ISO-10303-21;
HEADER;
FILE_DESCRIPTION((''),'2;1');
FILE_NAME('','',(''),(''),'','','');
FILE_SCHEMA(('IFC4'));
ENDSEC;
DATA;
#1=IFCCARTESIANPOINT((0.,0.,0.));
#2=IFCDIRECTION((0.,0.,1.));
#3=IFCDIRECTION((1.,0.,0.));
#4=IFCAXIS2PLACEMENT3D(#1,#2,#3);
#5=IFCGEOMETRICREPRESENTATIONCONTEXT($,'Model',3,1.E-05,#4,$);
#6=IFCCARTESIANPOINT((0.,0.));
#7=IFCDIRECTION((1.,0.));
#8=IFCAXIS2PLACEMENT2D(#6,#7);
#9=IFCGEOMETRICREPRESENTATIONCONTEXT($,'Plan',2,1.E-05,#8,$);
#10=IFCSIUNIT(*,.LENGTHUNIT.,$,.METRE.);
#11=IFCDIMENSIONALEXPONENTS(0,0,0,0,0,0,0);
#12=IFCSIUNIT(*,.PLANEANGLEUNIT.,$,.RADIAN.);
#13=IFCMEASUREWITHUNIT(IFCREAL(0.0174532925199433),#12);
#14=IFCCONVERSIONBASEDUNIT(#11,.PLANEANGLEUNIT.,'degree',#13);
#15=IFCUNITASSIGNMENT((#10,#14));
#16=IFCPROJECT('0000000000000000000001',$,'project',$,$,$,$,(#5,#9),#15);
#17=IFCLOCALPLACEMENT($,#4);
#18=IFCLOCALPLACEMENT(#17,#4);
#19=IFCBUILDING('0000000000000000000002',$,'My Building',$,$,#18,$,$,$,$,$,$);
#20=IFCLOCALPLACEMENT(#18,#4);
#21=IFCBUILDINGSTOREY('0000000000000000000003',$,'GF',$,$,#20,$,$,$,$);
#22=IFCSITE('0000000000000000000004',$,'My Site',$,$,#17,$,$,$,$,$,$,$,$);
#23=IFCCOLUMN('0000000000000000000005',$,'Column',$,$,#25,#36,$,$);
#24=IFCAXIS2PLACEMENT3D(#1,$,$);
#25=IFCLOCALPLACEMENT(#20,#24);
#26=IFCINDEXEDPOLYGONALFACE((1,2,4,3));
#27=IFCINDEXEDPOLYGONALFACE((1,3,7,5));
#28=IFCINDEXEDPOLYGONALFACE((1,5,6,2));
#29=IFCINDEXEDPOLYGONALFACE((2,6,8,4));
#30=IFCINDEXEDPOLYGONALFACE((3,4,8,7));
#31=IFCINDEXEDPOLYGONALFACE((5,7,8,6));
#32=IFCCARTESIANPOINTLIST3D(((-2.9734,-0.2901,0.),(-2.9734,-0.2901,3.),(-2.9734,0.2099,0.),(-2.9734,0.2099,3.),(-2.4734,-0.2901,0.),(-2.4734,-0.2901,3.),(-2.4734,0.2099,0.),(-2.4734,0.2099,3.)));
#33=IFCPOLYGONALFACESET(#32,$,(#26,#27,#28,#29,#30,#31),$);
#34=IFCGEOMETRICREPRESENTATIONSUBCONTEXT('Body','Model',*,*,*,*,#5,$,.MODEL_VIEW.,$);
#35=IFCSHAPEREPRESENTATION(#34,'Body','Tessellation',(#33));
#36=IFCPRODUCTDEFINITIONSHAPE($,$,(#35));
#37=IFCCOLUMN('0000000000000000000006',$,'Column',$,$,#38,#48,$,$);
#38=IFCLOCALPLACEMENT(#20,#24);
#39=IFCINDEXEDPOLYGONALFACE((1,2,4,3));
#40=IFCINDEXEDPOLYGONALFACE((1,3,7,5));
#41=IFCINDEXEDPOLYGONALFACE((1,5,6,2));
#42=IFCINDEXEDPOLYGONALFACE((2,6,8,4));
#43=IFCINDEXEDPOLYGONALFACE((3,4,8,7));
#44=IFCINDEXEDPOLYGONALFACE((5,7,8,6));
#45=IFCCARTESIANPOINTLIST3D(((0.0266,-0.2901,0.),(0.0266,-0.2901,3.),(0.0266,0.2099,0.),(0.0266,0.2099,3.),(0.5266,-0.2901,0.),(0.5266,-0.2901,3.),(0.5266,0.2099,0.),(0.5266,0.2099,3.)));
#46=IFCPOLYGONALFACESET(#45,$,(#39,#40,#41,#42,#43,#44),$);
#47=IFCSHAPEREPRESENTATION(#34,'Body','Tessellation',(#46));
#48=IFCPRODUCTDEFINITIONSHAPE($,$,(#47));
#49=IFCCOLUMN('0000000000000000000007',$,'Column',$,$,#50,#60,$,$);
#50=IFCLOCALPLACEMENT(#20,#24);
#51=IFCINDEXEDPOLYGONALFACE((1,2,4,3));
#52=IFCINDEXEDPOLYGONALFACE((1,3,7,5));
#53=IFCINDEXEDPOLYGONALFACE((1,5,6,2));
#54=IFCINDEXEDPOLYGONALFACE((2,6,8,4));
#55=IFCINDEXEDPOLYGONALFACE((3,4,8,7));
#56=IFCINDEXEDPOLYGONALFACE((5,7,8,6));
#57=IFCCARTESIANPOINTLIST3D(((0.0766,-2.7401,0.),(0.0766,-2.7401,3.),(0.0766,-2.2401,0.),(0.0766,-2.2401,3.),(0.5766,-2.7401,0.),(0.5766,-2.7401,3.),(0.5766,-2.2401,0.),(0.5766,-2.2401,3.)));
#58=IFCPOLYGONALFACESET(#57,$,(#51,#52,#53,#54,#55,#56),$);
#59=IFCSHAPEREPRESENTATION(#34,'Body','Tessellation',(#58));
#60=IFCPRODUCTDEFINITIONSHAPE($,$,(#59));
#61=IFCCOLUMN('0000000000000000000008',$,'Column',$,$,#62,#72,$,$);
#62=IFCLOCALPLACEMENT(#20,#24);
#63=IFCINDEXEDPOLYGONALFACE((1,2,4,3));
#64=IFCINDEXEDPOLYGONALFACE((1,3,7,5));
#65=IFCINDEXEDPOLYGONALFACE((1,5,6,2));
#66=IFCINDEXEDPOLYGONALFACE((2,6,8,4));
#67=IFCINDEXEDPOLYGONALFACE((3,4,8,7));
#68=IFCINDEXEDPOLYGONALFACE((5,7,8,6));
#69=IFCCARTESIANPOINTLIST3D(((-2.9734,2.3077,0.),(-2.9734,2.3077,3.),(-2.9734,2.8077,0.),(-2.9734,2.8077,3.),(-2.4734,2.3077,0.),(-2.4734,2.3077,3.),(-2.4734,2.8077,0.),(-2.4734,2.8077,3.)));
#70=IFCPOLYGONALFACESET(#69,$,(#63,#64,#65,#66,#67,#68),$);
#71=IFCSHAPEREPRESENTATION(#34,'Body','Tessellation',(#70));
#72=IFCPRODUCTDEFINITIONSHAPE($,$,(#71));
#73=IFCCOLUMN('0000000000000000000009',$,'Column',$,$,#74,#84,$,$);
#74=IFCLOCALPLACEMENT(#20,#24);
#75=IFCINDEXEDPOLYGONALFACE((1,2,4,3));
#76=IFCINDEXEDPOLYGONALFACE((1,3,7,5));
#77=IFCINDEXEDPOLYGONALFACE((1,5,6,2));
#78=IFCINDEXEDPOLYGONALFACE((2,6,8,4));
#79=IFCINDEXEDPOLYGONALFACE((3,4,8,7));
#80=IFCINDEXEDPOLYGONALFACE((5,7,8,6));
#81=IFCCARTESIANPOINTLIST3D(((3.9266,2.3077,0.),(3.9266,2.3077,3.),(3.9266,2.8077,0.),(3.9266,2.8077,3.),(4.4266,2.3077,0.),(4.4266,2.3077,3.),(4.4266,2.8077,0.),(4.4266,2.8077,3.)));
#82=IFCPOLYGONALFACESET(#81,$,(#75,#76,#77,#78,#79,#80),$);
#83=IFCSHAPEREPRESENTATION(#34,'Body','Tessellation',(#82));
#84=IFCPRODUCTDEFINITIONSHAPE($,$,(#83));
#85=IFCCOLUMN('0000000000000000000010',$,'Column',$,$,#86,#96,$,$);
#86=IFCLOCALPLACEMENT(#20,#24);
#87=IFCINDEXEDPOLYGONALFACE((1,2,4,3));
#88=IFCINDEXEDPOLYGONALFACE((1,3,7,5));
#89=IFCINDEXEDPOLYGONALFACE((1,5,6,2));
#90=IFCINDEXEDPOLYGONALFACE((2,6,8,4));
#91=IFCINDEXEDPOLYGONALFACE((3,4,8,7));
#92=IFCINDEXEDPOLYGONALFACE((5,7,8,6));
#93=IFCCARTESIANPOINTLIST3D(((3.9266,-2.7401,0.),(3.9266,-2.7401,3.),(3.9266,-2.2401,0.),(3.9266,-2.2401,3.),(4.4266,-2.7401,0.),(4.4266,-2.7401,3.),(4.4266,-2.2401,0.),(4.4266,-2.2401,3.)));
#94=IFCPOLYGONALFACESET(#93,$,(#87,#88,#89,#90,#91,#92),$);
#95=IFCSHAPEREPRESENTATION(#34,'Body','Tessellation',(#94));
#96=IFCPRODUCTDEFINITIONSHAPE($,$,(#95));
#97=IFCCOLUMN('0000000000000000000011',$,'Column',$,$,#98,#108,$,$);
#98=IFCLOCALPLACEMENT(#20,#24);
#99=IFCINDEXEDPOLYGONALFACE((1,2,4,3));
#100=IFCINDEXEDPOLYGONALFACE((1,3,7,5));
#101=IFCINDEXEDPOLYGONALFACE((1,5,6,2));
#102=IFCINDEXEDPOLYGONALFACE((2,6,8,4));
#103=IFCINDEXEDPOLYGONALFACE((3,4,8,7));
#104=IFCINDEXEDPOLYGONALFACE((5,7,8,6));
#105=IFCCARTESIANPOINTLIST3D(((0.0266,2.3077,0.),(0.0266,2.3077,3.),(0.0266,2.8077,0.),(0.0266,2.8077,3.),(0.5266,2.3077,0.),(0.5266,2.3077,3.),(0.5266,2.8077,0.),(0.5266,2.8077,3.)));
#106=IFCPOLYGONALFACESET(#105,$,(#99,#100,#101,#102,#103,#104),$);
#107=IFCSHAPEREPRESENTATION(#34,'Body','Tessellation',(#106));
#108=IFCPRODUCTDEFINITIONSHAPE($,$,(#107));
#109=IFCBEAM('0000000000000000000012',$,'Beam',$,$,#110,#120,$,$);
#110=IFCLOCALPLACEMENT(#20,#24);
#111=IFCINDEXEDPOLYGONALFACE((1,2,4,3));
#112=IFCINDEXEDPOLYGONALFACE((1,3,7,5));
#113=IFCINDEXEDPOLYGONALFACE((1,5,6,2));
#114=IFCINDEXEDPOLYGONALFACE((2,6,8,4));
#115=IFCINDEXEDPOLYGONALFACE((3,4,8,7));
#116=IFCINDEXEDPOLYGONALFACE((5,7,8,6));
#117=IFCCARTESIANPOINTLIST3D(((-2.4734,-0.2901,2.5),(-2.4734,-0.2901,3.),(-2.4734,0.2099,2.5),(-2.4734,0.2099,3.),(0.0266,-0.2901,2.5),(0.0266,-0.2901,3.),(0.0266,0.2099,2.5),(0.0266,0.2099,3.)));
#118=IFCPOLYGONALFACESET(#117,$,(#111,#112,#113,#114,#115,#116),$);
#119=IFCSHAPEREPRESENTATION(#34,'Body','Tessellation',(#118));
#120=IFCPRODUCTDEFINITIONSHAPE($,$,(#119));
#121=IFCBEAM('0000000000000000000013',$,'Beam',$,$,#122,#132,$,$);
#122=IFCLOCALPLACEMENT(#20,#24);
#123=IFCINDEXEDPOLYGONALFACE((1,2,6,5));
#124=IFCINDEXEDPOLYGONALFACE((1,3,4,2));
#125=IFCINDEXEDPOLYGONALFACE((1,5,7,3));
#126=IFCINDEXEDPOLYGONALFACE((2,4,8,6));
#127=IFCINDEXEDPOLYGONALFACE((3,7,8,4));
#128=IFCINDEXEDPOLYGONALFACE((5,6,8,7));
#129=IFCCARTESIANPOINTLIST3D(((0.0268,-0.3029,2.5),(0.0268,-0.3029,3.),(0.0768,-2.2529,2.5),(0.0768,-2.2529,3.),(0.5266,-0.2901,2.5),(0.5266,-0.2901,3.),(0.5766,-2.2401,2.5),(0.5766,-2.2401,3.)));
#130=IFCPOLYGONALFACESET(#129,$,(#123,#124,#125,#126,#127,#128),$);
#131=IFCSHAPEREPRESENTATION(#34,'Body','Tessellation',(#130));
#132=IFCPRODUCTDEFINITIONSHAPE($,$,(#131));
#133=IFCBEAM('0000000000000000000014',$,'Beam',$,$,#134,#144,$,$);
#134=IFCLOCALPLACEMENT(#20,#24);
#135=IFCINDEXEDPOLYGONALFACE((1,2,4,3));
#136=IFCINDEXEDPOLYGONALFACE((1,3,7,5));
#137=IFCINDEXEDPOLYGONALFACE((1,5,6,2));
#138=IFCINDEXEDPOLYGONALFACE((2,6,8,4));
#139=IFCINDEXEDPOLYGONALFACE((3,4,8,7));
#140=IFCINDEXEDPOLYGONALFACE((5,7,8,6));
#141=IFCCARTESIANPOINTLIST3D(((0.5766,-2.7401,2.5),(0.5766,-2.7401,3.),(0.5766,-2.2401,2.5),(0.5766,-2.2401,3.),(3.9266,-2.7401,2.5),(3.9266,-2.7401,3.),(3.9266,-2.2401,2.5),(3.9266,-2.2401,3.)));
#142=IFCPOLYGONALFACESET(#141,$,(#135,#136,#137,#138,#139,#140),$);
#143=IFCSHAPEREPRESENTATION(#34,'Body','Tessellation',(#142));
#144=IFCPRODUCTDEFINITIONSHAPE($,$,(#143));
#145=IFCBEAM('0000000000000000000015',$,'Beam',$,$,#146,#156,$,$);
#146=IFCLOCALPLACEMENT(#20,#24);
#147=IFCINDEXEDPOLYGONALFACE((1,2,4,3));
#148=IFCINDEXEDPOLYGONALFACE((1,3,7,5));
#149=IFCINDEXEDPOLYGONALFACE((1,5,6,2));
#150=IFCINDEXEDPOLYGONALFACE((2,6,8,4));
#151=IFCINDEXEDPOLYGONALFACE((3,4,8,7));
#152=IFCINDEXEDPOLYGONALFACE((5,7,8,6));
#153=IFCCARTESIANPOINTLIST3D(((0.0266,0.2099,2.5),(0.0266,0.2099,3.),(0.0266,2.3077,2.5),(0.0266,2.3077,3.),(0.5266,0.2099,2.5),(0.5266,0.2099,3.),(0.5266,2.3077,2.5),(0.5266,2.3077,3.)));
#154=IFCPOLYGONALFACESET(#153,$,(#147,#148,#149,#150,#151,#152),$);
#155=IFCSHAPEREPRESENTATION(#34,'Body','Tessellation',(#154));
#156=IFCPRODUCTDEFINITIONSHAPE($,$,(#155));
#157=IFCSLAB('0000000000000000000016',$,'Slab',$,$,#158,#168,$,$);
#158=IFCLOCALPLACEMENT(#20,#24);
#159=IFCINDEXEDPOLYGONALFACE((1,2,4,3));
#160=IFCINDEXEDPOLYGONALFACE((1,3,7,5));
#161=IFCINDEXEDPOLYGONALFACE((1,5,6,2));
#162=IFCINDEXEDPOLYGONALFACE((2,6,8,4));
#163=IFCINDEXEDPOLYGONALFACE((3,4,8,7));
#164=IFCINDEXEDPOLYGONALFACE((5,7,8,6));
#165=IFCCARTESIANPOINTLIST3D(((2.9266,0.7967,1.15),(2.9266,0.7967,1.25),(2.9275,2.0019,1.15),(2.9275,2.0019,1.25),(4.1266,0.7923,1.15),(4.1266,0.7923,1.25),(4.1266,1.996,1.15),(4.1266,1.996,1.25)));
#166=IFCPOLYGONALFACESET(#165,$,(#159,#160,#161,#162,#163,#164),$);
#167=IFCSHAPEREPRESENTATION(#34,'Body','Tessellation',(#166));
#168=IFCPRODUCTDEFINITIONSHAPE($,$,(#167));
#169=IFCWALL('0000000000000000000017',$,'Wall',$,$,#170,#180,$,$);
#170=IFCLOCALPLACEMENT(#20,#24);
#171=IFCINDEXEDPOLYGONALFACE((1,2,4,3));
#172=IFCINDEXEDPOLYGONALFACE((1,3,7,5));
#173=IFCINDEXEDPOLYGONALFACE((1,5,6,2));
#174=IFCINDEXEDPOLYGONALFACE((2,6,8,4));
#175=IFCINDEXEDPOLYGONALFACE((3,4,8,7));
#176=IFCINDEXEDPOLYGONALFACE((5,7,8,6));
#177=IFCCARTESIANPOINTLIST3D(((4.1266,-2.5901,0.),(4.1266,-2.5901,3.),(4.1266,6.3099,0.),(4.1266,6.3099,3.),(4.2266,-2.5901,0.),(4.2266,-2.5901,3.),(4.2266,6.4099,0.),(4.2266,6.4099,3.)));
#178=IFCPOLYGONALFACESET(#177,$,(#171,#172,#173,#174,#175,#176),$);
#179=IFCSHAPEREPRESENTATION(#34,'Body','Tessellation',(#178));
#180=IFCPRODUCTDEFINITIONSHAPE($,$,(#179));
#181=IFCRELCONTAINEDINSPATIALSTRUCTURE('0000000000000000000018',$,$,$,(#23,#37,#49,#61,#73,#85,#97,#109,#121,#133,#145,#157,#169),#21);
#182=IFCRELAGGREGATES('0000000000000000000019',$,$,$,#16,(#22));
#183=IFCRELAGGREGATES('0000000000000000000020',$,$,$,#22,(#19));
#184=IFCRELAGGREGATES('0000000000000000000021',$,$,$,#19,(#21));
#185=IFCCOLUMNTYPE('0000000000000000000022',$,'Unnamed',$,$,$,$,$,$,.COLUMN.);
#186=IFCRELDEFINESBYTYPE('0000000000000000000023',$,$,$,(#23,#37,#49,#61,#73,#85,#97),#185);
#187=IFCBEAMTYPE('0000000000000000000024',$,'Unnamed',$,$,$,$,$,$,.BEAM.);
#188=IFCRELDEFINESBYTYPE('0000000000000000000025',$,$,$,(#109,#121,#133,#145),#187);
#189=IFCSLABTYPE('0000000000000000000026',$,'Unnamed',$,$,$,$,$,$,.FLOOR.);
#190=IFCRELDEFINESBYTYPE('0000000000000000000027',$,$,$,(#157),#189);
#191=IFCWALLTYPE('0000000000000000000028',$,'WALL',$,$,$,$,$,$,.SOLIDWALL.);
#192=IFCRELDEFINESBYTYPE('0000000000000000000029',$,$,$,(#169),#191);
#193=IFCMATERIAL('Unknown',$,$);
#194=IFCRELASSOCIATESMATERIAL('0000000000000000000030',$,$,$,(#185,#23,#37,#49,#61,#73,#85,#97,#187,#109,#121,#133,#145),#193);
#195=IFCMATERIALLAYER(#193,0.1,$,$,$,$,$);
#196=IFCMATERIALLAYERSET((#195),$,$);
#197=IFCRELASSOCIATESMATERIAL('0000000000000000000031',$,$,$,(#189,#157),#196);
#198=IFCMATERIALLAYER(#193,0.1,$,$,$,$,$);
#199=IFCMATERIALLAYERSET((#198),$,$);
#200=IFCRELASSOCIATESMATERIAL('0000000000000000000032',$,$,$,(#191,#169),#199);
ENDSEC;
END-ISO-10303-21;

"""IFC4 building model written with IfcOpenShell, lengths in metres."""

from ifc_helpers import new_model, entity, si_unit, converted_unit, frame, origin_with_axes, origin_2d_with_axis, place, context, subcontext, project, spatial, line, indexed_curve, rectangle, outline, extrude, material, layer, layer_set, layer_usage, material_profile, profile_set, profile_usage, type_object, element, save


model = new_model("IFC4")

# Units and contexts
model_context = context("Model", 3, precision=1e-05, world=origin_with_axes())
plan_context = context("Plan", 2, precision=1e-05, world=origin_2d_with_axis())
body_context_1 = subcontext(model_context, "Body", "Model", "MODEL_VIEW")
ifc_project = project(units=[si_unit("LENGTHUNIT", "METRE"), converted_unit("PLANEANGLEUNIT", "degree", entity("IfcReal", 0.0174532925199433), si_unit("PLANEANGLEUNIT", "RADIAN"), dimensions=[0, 0, 0, 0, 0, 0, 0])], contexts=[model_context, plan_context])

# Site, building, storey
site_placement = place(None, origin_with_axes())
site = spatial("IfcSite", under=ifc_project, at=site_placement, Name="My Site")
building_placement = place(site_placement, origin_with_axes())
building = spatial("IfcBuilding", under=site, at=building_placement, Name="My Building")
storey_placement = place(building_placement, origin_with_axes())
storey = spatial("IfcBuildingStorey", under=building, at=storey_placement, Name="GF")

# Columns
ifc_material_1 = material(Name="Unknown")
ifc_material_profile_1 = material_profile(ifc_material_1, rectangle(XDim=0.5, YDim=0.5))
ifc_profile_set_1 = profile_set([ifc_material_profile_1])
ifc_profile_usage_1 = profile_usage(ifc_profile_set_1, cardinal=5)
column_type = type_object("IfcColumnType", Name="Unnamed", PredefinedType="COLUMN", material=ifc_profile_set_1)
column_1_placement = place(storey_placement, frame((-2.7234, -0.0401, 0.0), z_axis=(0.0, 0.0, 1.0), x_axis=(1.0, 0.0, 0.0)))
element("IfcColumn", 1, at=column_1_placement, inside=storey, type_object=column_type, material=ifc_profile_usage_1, Name="Column", context=body_context_1, shape_type="SweptSolid", body=[
    extrude(rectangle(XDim=0.5, YDim=0.5), origin_with_axes(), (0.0, 0.0, 1.0), 3.0),
])
ifc_profile_usage_2 = profile_usage(ifc_profile_set_1, cardinal=5)
column_2_placement = place(storey_placement, frame((0.2766, -0.0401, 0.0), z_axis=(0.0, 0.0, 1.0), x_axis=(1.0, 0.0, 0.0)))
element("IfcColumn", 2, at=column_2_placement, inside=storey, type_object=column_type, material=ifc_profile_usage_2, Name="Column", context=body_context_1, shape_type="SweptSolid", body=[
    extrude(rectangle(XDim=0.5, YDim=0.5), origin_with_axes(), (0.0, 0.0, 1.0), 3.0),
])
ifc_profile_usage_3 = profile_usage(ifc_profile_set_1, cardinal=5)
column_3_placement = place(storey_placement, frame((0.3266, -2.4901, 0.0), z_axis=(0.0, 0.0, 1.0), x_axis=(1.0, 0.0, 0.0)))
element("IfcColumn", 3, at=column_3_placement, inside=storey, type_object=column_type, material=ifc_profile_usage_3, Name="Column", context=body_context_1, shape_type="SweptSolid", body=[
    extrude(rectangle(XDim=0.5, YDim=0.5), origin_with_axes(), (0.0, 0.0, 1.0), 3.0),
])
ifc_profile_usage_4 = profile_usage(ifc_profile_set_1, cardinal=5)
column_4_placement = place(storey_placement, frame((-2.7234, 2.5577, 0.0), z_axis=(0.0, 0.0, 1.0), x_axis=(1.0, 0.0, 0.0)))
element("IfcColumn", 4, at=column_4_placement, inside=storey, type_object=column_type, material=ifc_profile_usage_4, Name="Column", context=body_context_1, shape_type="SweptSolid", body=[
    extrude(rectangle(XDim=0.5, YDim=0.5), origin_with_axes(), (0.0, 0.0, 1.0), 3.0),
])
ifc_profile_usage_5 = profile_usage(ifc_profile_set_1, cardinal=5)
column_5_placement = place(storey_placement, frame((4.1766, 2.5577, 0.0), z_axis=(0.0, 0.0, 1.0), x_axis=(1.0, 0.0, 0.0)))
element("IfcColumn", 5, at=column_5_placement, inside=storey, type_object=column_type, material=ifc_profile_usage_5, Name="Column", context=body_context_1, shape_type="SweptSolid", body=[
    extrude(rectangle(XDim=0.5, YDim=0.5), origin_with_axes(), (0.0, 0.0, 1.0), 3.0),
])
ifc_profile_usage_6 = profile_usage(ifc_profile_set_1, cardinal=5)
column_6_placement = place(storey_placement, frame((4.1766, -2.4901, 0.0), z_axis=(0.0, 0.0, 1.0), x_axis=(1.0, 0.0, 0.0)))
element("IfcColumn", 6, at=column_6_placement, inside=storey, type_object=column_type, material=ifc_profile_usage_6, Name="Column", context=body_context_1, shape_type="SweptSolid", body=[
    extrude(rectangle(XDim=0.5, YDim=0.5), origin_with_axes(), (0.0, 0.0, 1.0), 3.0),
])
ifc_profile_usage_7 = profile_usage(ifc_profile_set_1, cardinal=5)
column_7_placement = place(storey_placement, frame((0.2766, 2.5577, 0.0), z_axis=(0.0, 0.0, 1.0), x_axis=(1.0, 0.0, 0.0)))
element("IfcColumn", 7, at=column_7_placement, inside=storey, type_object=column_type, material=ifc_profile_usage_7, Name="Column", context=body_context_1, shape_type="SweptSolid", body=[
    extrude(rectangle(XDim=0.5, YDim=0.5), origin_with_axes(), (0.0, 0.0, 1.0), 3.0),
])

# Beams
ifc_material_profile_2 = material_profile(ifc_material_1, rectangle(XDim=0.5, YDim=0.5))
ifc_profile_set_2 = profile_set([ifc_material_profile_2])
ifc_profile_usage_8 = profile_usage(ifc_profile_set_2, cardinal=7)
beam_type = type_object("IfcBeamType", Name="Unnamed", PredefinedType="BEAM", material=ifc_profile_set_2)
beam_1_placement = place(storey_placement, frame((-2.4734, 0.2099, 3.0), z_axis=(1.0, 0.0, 0.0), x_axis=(0.0, 1.0, 0.0)))
element("IfcBeam", 8, at=beam_1_placement, inside=storey, type_object=beam_type, material=ifc_profile_usage_8, Name="Beam", context=body_context_1, shape_type="SweptSolid", body=[
    extrude(rectangle(XDim=0.5, YDim=0.5), frame((-0.25, -0.25, 0.0), z_axis=(0.0, 0.0, 1.0), x_axis=(1.0, 0.0, 0.0)), (0.0, 0.0, 1.0), 2.5),
])
ifc_profile_usage_9 = profile_usage(ifc_profile_set_2, cardinal=7)
beam_2_placement = place(storey_placement, frame((0.5266, -0.2901, 3.0), z_axis=(0.025633, -0.999671, 0.0), x_axis=(0.999671, 0.025633, 0.0)))
element("IfcBeam", 9, at=beam_2_placement, inside=storey, type_object=beam_type, material=ifc_profile_usage_9, Name="Beam", context=body_context_1, shape_type="SweptSolid", body=[
    extrude(rectangle(XDim=0.5, YDim=0.5), frame((-0.25, -0.25, 0.0), z_axis=(0.0, 0.0, 1.0), x_axis=(1.0, 0.0, 0.0)), (0.0, 0.0, 1.0), 1.9506),
])
ifc_profile_usage_10 = profile_usage(ifc_profile_set_2, cardinal=7)
beam_3_placement = place(storey_placement, frame((0.5766, -2.2401, 3.0), z_axis=(1.0, 0.0, 0.0), x_axis=(0.0, 1.0, 0.0)))
element("IfcBeam", 10, at=beam_3_placement, inside=storey, type_object=beam_type, material=ifc_profile_usage_10, Name="Beam", context=body_context_1, shape_type="SweptSolid", body=[
    extrude(rectangle(XDim=0.5, YDim=0.5), frame((-0.25, -0.25, 0.0), z_axis=(0.0, 0.0, 1.0), x_axis=(1.0, 0.0, 0.0)), (0.0, 0.0, 1.0), 3.35),
])
ifc_profile_usage_11 = profile_usage(ifc_profile_set_2, cardinal=7)
beam_4_placement = place(storey_placement, frame((0.5266, 2.3077, 3.0), z_axis=(0.0, -1.0, 0.0), x_axis=(1.0, 0.0, 0.0)))
element("IfcBeam", 11, at=beam_4_placement, inside=storey, type_object=beam_type, material=ifc_profile_usage_11, Name="Beam", context=body_context_1, shape_type="SweptSolid", body=[
    extrude(rectangle(XDim=0.5, YDim=0.5), frame((-0.25, -0.25, 0.0), z_axis=(0.0, 0.0, 1.0), x_axis=(1.0, 0.0, 0.0)), (0.0, 0.0, 1.0), 2.0978),
])

# Slab
ifc_layer_1 = layer(ifc_material_1, 0.1)
ifc_layer_set_1 = layer_set([ifc_layer_1])
ifc_layer_usage_1 = layer_usage(ifc_layer_set_1, "AXIS3", "POSITIVE", -0.1)
slab_type = type_object("IfcSlabType", Name="Unnamed", PredefinedType="FLOOR", material=ifc_layer_set_1)
slab_placement = place(storey_placement, frame((2.9266, 0.7967, 1.25), z_axis=(0.0, 0.0, 1.0), x_axis=(1.0, 0.0, 0.0)))
element("IfcSlab", 12, at=slab_placement, inside=storey, type_object=slab_type, material=ifc_layer_usage_1, Name="Slab", context=body_context_1, shape_type="SweptSolid", body=[
    extrude(outline(indexed_curve([(0.0, 0.0), (1.2, -0.0044), (1.2, 1.1993), (0.0009, 1.2051), (0.0, 0.0)])), frame((0.0, 0.0, -0.1), z_axis=(0.0, 0.0, 1.0), x_axis=(1.0, 0.0, 0.0)), (0.0, 0.0, 1.0), 0.1),
])

# Wall
ifc_layer_2 = layer(ifc_material_1, 0.1)
ifc_layer_set_2 = layer_set([ifc_layer_2])
ifc_layer_usage_2 = layer_usage(ifc_layer_set_2, "AXIS2", "POSITIVE", 0.0)
wall_type = type_object("IfcWallType", Name="WALL", PredefinedType="SOLIDWALL", material=ifc_layer_set_2)
wall_1_placement = place(storey_placement, frame((4.2266, -2.5901, 0.0), z_axis=(0.0, 0.0, 1.0), x_axis=(0.0, 1.0, 0.0)))
element("IfcWall", 13, at=wall_1_placement, inside=storey, type_object=wall_type, material=ifc_layer_usage_2, Name="Wall", context=body_context_1, shape_type="SweptSolid", body=[
    extrude(outline(indexed_curve([(0.0, 0.0), (0.0, 0.1), (8.9, 0.1), (9.0, 0.0)], segments=[line(1, 2, 3, 4, 1)])), origin_with_axes(), (0.0, 0.0, 1.0), 3.0),
])

save(model, "model.ifc")
